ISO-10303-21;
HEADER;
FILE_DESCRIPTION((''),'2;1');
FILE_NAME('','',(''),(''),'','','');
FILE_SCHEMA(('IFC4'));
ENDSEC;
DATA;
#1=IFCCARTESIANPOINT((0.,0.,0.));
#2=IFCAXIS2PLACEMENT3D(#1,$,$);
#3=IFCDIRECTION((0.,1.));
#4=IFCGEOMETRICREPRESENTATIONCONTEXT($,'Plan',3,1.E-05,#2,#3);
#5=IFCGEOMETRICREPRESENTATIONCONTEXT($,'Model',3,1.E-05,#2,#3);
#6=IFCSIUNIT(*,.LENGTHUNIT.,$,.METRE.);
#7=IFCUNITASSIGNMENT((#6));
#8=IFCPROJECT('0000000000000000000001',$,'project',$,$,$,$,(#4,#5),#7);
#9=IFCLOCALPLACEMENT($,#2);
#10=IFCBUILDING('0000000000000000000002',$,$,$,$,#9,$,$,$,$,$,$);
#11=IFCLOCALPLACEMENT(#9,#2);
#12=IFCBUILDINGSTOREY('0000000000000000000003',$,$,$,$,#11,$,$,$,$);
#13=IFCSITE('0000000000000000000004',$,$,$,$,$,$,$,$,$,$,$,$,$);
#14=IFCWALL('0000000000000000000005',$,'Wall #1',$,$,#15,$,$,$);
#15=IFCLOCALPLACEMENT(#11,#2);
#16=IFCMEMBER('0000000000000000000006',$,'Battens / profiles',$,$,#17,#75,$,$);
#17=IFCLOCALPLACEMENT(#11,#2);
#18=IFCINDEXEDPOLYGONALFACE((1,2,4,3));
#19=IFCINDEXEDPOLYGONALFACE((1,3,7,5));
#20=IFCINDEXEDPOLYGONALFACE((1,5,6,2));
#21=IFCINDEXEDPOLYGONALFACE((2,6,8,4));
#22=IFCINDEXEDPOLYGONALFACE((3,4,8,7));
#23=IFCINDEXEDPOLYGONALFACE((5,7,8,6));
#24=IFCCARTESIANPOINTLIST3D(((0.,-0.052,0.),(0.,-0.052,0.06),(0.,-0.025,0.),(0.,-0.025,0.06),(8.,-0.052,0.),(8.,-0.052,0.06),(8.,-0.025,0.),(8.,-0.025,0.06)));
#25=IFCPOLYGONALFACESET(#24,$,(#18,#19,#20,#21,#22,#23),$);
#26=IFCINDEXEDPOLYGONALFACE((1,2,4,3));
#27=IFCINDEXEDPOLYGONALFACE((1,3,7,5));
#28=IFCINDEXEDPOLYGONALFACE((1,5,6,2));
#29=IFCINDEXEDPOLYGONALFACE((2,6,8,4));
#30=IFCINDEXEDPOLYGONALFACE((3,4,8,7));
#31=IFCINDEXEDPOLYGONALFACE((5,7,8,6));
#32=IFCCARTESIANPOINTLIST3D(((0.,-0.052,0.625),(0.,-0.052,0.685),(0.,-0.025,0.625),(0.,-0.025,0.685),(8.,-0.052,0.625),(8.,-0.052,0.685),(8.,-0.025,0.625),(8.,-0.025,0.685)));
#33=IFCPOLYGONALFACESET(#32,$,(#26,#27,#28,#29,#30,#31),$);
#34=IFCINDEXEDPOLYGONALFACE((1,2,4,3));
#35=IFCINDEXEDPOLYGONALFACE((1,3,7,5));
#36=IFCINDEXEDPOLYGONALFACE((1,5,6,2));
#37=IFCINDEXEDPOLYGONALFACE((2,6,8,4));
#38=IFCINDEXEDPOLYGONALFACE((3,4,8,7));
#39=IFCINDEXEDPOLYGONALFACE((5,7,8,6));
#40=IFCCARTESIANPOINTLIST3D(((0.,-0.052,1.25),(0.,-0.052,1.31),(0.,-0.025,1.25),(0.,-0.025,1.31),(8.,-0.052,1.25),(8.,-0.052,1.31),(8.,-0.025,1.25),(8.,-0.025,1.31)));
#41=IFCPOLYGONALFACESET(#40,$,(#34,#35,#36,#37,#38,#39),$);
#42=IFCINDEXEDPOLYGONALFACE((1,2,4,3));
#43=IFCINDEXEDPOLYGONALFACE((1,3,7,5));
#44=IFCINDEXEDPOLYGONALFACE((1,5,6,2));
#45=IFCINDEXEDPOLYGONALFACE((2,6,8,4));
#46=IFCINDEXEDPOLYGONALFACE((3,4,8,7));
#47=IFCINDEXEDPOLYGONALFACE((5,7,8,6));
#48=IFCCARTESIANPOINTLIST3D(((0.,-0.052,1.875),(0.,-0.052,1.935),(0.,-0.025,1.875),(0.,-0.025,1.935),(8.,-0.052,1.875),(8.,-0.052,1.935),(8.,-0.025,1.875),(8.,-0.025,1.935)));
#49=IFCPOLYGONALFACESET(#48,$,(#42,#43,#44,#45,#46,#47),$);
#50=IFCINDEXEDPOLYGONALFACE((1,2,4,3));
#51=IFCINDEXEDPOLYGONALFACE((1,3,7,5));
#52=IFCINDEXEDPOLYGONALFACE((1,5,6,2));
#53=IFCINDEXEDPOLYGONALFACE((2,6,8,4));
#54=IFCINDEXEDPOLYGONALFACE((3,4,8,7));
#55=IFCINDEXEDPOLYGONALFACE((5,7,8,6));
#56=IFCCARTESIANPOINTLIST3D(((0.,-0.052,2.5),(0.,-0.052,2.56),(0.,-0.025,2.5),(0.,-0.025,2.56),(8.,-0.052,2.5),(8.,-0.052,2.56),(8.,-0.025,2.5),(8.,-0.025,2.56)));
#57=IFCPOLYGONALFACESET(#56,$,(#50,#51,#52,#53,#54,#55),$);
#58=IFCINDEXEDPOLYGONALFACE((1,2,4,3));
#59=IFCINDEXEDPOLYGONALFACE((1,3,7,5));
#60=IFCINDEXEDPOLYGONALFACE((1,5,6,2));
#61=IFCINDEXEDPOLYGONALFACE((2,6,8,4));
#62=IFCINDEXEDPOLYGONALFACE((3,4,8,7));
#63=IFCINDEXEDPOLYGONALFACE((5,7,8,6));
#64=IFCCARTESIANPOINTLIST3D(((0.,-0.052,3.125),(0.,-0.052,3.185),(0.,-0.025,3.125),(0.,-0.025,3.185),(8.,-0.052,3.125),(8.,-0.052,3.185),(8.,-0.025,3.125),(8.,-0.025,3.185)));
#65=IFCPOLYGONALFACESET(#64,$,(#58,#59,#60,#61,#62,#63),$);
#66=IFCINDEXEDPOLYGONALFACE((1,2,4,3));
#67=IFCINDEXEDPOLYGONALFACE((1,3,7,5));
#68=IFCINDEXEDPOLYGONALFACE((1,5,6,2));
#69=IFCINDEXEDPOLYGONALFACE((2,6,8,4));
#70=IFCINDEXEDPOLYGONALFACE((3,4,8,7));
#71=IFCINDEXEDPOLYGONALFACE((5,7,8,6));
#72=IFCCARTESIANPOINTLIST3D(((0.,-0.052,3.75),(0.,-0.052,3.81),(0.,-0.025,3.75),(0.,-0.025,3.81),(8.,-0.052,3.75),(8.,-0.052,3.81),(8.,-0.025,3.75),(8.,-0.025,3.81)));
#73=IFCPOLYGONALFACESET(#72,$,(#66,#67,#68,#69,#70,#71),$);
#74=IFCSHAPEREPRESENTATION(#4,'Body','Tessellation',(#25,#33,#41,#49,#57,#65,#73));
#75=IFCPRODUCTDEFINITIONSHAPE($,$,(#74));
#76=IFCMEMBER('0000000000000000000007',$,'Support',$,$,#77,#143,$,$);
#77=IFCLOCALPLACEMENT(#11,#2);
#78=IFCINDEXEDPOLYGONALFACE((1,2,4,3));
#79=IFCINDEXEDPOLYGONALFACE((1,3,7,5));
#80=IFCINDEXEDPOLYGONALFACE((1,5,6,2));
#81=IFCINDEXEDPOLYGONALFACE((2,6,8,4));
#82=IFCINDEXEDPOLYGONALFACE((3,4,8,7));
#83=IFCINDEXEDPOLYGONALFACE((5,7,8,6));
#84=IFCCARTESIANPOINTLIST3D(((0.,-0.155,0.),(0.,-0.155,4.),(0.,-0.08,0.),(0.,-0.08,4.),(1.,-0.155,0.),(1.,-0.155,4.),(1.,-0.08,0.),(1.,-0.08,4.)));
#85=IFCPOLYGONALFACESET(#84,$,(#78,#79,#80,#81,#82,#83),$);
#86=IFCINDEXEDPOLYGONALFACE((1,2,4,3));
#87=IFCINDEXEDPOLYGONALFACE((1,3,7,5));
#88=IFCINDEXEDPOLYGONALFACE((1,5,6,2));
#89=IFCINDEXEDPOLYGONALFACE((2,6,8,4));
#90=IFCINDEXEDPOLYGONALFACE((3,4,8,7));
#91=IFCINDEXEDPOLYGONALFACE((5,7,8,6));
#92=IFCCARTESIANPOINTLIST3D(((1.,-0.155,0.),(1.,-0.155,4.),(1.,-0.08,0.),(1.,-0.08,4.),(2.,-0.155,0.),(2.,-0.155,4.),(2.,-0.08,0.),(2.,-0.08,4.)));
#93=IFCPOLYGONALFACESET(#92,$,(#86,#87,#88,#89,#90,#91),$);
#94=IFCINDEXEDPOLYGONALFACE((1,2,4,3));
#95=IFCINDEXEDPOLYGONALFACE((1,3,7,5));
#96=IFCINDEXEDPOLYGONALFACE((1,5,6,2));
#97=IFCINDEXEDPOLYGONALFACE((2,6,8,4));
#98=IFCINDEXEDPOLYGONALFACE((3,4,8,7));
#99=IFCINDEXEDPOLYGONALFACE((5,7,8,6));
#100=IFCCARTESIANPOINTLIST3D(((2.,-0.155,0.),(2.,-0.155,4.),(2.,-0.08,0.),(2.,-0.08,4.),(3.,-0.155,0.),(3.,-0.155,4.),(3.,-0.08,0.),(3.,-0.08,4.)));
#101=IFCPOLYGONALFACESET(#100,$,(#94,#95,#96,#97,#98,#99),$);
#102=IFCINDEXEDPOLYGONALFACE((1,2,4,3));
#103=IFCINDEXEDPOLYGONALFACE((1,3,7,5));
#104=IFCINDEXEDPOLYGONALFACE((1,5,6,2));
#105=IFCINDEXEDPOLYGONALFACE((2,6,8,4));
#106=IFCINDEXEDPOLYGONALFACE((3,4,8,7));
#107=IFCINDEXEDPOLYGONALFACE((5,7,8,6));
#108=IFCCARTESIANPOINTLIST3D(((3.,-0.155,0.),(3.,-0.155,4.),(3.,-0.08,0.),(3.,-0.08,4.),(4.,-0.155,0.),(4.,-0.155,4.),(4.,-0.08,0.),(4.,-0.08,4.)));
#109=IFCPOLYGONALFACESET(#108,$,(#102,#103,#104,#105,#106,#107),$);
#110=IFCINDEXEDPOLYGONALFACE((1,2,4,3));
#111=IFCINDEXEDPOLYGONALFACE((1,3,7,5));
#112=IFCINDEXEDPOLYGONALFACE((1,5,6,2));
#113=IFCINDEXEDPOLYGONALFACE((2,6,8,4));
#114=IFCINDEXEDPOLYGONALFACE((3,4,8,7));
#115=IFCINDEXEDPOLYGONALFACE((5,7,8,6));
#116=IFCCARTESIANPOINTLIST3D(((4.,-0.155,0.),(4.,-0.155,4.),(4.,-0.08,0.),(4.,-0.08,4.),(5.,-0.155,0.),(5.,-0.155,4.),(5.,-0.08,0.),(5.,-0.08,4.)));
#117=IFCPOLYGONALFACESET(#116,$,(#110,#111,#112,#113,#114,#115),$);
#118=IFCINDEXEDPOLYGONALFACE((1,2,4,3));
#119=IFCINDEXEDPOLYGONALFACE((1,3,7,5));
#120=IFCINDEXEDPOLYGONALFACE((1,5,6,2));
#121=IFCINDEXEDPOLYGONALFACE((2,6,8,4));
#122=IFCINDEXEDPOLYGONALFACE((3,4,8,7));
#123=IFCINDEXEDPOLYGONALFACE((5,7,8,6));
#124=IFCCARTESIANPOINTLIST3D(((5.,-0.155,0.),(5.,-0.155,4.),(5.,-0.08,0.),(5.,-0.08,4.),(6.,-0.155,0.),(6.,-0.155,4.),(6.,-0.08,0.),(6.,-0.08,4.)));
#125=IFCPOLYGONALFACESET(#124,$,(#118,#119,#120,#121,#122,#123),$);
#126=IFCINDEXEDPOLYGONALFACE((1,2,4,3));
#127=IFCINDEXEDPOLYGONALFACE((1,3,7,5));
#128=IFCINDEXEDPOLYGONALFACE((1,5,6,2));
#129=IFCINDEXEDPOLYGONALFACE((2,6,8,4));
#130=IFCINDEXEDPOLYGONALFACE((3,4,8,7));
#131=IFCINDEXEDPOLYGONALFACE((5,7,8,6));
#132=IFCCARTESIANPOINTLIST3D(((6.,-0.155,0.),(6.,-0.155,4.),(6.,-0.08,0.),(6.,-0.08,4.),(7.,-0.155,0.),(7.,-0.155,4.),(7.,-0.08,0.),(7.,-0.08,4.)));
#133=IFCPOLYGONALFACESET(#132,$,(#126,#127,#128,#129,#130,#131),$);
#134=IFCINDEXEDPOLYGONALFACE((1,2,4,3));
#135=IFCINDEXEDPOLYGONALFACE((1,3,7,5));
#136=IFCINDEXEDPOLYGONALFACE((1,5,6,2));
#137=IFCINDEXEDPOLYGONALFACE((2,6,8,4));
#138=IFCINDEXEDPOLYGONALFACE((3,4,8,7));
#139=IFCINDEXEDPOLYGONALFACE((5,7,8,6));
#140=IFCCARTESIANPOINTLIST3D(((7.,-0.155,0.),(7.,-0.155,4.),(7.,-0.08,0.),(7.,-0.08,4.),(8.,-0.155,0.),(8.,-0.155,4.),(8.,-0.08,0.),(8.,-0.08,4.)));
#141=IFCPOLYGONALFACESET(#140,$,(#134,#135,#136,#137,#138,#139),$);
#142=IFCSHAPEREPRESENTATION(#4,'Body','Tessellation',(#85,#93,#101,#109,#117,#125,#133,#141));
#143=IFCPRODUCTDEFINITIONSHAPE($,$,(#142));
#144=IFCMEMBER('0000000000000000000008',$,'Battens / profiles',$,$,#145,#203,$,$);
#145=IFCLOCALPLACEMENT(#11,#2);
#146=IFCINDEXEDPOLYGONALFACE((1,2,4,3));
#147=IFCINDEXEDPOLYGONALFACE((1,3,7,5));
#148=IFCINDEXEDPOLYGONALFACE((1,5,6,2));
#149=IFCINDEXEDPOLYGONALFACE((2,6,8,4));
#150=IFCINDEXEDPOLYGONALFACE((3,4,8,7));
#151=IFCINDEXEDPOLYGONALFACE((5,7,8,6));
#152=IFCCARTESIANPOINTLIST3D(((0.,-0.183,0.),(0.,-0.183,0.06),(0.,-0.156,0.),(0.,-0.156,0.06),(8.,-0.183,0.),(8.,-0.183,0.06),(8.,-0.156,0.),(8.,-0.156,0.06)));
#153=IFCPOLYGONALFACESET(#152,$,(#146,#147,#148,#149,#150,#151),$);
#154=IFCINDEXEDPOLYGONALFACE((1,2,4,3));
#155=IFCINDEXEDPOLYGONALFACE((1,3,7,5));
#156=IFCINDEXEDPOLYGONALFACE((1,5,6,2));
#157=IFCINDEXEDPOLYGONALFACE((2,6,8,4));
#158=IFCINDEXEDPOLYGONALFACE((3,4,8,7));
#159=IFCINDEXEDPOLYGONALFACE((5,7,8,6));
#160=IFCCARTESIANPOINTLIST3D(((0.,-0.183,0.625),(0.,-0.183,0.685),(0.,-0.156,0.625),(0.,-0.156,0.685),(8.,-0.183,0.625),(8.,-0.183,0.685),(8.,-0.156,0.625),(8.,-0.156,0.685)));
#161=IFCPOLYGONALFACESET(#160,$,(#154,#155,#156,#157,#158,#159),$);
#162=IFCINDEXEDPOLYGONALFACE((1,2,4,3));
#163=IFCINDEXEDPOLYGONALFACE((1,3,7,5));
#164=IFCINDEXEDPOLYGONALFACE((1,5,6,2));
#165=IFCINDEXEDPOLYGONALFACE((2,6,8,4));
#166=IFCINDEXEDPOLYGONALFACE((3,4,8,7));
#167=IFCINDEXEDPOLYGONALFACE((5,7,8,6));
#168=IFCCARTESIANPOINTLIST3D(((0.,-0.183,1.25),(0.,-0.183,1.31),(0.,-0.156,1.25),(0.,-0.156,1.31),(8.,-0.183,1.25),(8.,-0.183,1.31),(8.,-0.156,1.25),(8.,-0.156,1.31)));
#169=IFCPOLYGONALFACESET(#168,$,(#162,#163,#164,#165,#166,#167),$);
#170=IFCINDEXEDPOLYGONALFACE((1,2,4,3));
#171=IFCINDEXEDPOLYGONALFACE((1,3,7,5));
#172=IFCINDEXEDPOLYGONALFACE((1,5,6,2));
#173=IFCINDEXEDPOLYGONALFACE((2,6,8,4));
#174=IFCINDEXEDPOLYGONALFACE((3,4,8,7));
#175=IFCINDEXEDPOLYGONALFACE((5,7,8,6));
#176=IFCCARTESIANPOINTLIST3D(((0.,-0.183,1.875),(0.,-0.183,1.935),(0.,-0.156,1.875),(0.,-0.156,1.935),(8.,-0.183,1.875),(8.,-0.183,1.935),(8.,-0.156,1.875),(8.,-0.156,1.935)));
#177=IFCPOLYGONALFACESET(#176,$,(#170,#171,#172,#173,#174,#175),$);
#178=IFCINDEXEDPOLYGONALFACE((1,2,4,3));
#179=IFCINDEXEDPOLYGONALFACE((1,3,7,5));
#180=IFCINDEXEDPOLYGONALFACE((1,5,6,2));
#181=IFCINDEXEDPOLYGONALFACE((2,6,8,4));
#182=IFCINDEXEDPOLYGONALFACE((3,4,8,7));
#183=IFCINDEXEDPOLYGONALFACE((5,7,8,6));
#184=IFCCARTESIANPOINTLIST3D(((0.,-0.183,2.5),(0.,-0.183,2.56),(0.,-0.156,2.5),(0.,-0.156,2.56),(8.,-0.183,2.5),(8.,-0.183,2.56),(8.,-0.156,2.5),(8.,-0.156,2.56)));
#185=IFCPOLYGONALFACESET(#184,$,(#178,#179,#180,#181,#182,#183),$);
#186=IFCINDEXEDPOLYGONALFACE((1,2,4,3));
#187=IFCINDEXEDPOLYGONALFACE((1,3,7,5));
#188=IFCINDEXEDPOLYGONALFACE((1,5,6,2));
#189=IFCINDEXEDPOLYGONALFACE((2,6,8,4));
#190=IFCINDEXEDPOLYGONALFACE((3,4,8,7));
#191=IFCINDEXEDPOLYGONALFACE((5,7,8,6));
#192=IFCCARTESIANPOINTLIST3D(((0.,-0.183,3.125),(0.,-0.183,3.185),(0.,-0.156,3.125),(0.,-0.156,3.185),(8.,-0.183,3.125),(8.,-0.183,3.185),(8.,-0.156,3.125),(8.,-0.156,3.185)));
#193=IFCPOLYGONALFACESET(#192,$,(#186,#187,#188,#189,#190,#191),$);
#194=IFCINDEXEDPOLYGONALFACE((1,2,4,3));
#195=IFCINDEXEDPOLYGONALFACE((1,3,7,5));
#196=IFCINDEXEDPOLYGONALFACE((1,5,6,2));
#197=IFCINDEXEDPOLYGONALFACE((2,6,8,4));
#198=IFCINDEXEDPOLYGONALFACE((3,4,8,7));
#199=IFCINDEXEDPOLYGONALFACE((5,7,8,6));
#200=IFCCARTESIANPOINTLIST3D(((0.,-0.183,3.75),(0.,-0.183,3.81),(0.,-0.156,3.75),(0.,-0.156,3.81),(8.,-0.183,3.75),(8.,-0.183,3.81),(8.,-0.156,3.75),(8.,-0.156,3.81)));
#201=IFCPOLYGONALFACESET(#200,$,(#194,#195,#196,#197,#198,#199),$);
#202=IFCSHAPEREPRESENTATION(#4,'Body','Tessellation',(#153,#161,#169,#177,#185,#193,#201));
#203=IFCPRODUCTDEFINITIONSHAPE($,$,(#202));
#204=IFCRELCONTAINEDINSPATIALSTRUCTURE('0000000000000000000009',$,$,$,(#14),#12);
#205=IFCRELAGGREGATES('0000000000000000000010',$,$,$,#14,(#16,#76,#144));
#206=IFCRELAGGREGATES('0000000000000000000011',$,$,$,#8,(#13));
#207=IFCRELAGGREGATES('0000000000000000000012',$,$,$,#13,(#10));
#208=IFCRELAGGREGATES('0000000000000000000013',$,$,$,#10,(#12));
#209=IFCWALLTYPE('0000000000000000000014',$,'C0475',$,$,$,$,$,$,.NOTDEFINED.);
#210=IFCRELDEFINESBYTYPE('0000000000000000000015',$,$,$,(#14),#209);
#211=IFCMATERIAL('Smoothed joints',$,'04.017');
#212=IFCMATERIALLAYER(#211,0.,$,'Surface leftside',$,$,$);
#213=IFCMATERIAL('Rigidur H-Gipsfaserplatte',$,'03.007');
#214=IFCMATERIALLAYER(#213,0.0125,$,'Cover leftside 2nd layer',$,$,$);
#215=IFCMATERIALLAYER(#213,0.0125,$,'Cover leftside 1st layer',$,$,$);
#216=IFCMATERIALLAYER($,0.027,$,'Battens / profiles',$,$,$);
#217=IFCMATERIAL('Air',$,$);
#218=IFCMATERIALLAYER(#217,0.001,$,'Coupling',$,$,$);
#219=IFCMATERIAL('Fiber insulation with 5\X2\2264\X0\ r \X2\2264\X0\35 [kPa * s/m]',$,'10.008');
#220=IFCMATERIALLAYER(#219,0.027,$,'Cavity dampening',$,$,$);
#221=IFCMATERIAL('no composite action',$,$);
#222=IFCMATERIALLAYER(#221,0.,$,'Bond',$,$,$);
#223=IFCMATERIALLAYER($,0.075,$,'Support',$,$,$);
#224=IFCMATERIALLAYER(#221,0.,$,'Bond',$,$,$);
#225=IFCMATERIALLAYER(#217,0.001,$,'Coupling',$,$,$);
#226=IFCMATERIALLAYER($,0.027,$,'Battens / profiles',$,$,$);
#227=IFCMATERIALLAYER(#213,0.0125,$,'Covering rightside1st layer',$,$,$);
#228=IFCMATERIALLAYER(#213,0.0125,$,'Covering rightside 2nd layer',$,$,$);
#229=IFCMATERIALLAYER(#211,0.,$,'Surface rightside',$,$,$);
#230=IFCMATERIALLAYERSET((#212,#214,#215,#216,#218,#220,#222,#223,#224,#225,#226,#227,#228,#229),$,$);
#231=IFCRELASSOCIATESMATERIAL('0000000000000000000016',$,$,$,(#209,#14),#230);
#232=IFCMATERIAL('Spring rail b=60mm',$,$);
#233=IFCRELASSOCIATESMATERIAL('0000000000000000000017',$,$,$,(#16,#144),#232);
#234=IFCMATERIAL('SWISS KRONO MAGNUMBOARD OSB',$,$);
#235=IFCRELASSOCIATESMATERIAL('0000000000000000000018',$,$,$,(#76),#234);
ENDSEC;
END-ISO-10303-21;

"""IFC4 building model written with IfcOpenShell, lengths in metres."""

from ifc_helpers import new_model, si_unit, direction, frame, frame_2d, origin, place, context, project, spatial, rectangle, extrude, material, layer, layer_set, type_object, element, aggregate, save


model = new_model("IFC4")

# Units and contexts
plan_context = context("Plan", 3, precision=1e-05, world=origin(), true_north=direction((0.0, 1.0)))
model_context = context("Model", 3, precision=1e-05, world=origin(), true_north=direction((0.0, 1.0)))
ifc_project = project(units=[si_unit("LENGTHUNIT", "METRE")], contexts=[plan_context, model_context])

# Site, building, storey
site = spatial("IfcSite", under=ifc_project)
building_placement = place(None, origin())
building = spatial("IfcBuilding", under=site, at=building_placement)
storey_placement = place(building_placement, origin())
storey = spatial("IfcBuildingStorey", under=building, at=storey_placement)

# Wall, members
ifc_material_1 = material(Name="Smoothed joints", Category="04.017")
ifc_layer_1 = layer(ifc_material_1, 0.0, Name="Surface leftside")
ifc_material_2 = material(Name="Rigidur H-Gipsfaserplatte", Category="03.007")
ifc_layer_2 = layer(ifc_material_2, 0.0125, Name="Cover leftside 2nd layer")
ifc_layer_3 = layer(ifc_material_2, 0.0125, Name="Cover leftside 1st layer")
ifc_layer_4 = layer(None, 0.027, Name="Battens / profiles")
ifc_material_3 = material(Name="Air")
ifc_layer_5 = layer(ifc_material_3, 0.001, Name="Coupling")
ifc_material_4 = material(Name="Fiber insulation with 5≤ r ≤35 [kPa * s/m]", Category="10.008")
ifc_layer_6 = layer(ifc_material_4, 0.027, Name="Cavity dampening")
ifc_material_5 = material(Name="no composite action")
ifc_layer_7 = layer(ifc_material_5, 0.0, Name="Bond")
ifc_layer_8 = layer(None, 0.075, Name="Support")
ifc_layer_9 = layer(ifc_material_5, 0.0, Name="Bond")
ifc_layer_10 = layer(ifc_material_3, 0.001, Name="Coupling")
ifc_layer_11 = layer(None, 0.027, Name="Battens / profiles")
ifc_layer_12 = layer(ifc_material_2, 0.0125, Name="Covering rightside1st layer")
ifc_layer_13 = layer(ifc_material_2, 0.0125, Name="Covering rightside 2nd layer")
ifc_layer_14 = layer(ifc_material_1, 0.0, Name="Surface rightside")
ifc_layer_set = layer_set([ifc_layer_1, ifc_layer_2, ifc_layer_3, ifc_layer_4, ifc_layer_5, ifc_layer_6, ifc_layer_7, ifc_layer_8, ifc_layer_9, ifc_layer_10, ifc_layer_11, ifc_layer_12, ifc_layer_13, ifc_layer_14])
wall_type = type_object("IfcWallType", Name="C0475", PredefinedType="NOTDEFINED", material=ifc_layer_set)
wall_placement = place(None, frame((0.0, 0.0, 0.0), z_axis=(0.0, -1.0, 0.0), x_axis=(1.0, 0.0, 0.0)))
wall = element("IfcWall", 1, at=wall_placement, inside=storey, type_object=wall_type, material=ifc_layer_set, Name="Wall #1")
ifc_material_6 = material(Name="Spring rail b=60mm")
member_1_placement = place(wall_placement, origin())
member_1 = element("IfcMember", 2, at=member_1_placement, material=ifc_material_6, Name="Battens / profiles", context=plan_context, shape_type="SweptSolid", body=[
    extrude(rectangle(XDim=0.06, YDim=0.027, at=frame_2d((0.03, 0.0135), x_axis=(1.0, 0.0))), frame((0.0, 0.0, 0.025), z_axis=(1.0, 0.0, 0.0), x_axis=(0.0, 1.0, 0.0)), (0.0, 0.0, 1.0), 8.0),
    extrude(rectangle(XDim=0.06, YDim=0.027, at=frame_2d((0.03, 0.0135), x_axis=(1.0, 0.0))), frame((0.0, 0.625, 0.025), z_axis=(1.0, 0.0, 0.0), x_axis=(0.0, 1.0, 0.0)), (0.0, 0.0, 1.0), 8.0),
    extrude(rectangle(XDim=0.06, YDim=0.027, at=frame_2d((0.03, 0.0135), x_axis=(1.0, 0.0))), frame((0.0, 1.25, 0.025), z_axis=(1.0, 0.0, 0.0), x_axis=(0.0, 1.0, 0.0)), (0.0, 0.0, 1.0), 8.0),
    extrude(rectangle(XDim=0.06, YDim=0.027, at=frame_2d((0.03, 0.0135), x_axis=(1.0, 0.0))), frame((0.0, 1.875, 0.025), z_axis=(1.0, 0.0, 0.0), x_axis=(0.0, 1.0, 0.0)), (0.0, 0.0, 1.0), 8.0),
    extrude(rectangle(XDim=0.06, YDim=0.027, at=frame_2d((0.03, 0.0135), x_axis=(1.0, 0.0))), frame((0.0, 2.5, 0.025), z_axis=(1.0, 0.0, 0.0), x_axis=(0.0, 1.0, 0.0)), (0.0, 0.0, 1.0), 8.0),
    extrude(rectangle(XDim=0.06, YDim=0.027, at=frame_2d((0.03, 0.0135), x_axis=(1.0, 0.0))), frame((0.0, 3.125, 0.025), z_axis=(1.0, 0.0, 0.0), x_axis=(0.0, 1.0, 0.0)), (0.0, 0.0, 1.0), 8.0),
    extrude(rectangle(XDim=0.06, YDim=0.027, at=frame_2d((0.03, 0.0135), x_axis=(1.0, 0.0))), frame((0.0, 3.75, 0.025), z_axis=(1.0, 0.0, 0.0), x_axis=(0.0, 1.0, 0.0)), (0.0, 0.0, 1.0), 8.0),
])
ifc_material_7 = material(Name="SWISS KRONO MAGNUMBOARD OSB")
member_2_placement = place(wall_placement, origin())
member_2 = element("IfcMember", 3, at=member_2_placement, material=ifc_material_7, Name="Support", context=plan_context, shape_type="SweptSolid", body=[
    extrude(rectangle(XDim=1.0, YDim=0.075, at=frame_2d((0.5, 0.0375), x_axis=(1.0, 0.0))), frame((0.0, 4.0, 0.08), z_axis=(0.0, -1.0, 0.0), x_axis=(1.0, 0.0, 0.0)), (0.0, 0.0, 1.0), 4.0),
    extrude(rectangle(XDim=1.0, YDim=0.075, at=frame_2d((0.5, 0.0375), x_axis=(1.0, 0.0))), frame((1.0, 4.0, 0.08), z_axis=(0.0, -1.0, 0.0), x_axis=(1.0, 0.0, 0.0)), (0.0, 0.0, 1.0), 4.0),
    extrude(rectangle(XDim=1.0, YDim=0.075, at=frame_2d((0.5, 0.0375), x_axis=(1.0, 0.0))), frame((2.0, 4.0, 0.08), z_axis=(0.0, -1.0, 0.0), x_axis=(1.0, 0.0, 0.0)), (0.0, 0.0, 1.0), 4.0),
    extrude(rectangle(XDim=1.0, YDim=0.075, at=frame_2d((0.5, 0.0375), x_axis=(1.0, 0.0))), frame((3.0, 4.0, 0.08), z_axis=(0.0, -1.0, 0.0), x_axis=(1.0, 0.0, 0.0)), (0.0, 0.0, 1.0), 4.0),
    extrude(rectangle(XDim=1.0, YDim=0.075, at=frame_2d((0.5, 0.0375), x_axis=(1.0, 0.0))), frame((4.0, 4.0, 0.08), z_axis=(0.0, -1.0, 0.0), x_axis=(1.0, 0.0, 0.0)), (0.0, 0.0, 1.0), 4.0),
    extrude(rectangle(XDim=1.0, YDim=0.075, at=frame_2d((0.5, 0.0375), x_axis=(1.0, 0.0))), frame((5.0, 4.0, 0.08), z_axis=(0.0, -1.0, 0.0), x_axis=(1.0, 0.0, 0.0)), (0.0, 0.0, 1.0), 4.0),
    extrude(rectangle(XDim=1.0, YDim=0.075, at=frame_2d((0.5, 0.0375), x_axis=(1.0, 0.0))), frame((6.0, 4.0, 0.08), z_axis=(0.0, -1.0, 0.0), x_axis=(1.0, 0.0, 0.0)), (0.0, 0.0, 1.0), 4.0),
    extrude(rectangle(XDim=1.0, YDim=0.075, at=frame_2d((0.5, 0.0375), x_axis=(1.0, 0.0))), frame((7.0, 4.0, 0.08), z_axis=(0.0, -1.0, 0.0), x_axis=(1.0, 0.0, 0.0)), (0.0, 0.0, 1.0), 4.0),
])
member_3_placement = place(wall_placement, origin())
member_3 = element("IfcMember", 4, at=member_3_placement, material=ifc_material_6, Name="Battens / profiles", context=plan_context, shape_type="SweptSolid", body=[
    extrude(rectangle(XDim=0.06, YDim=0.027, at=frame_2d((0.03, 0.0135), x_axis=(1.0, 0.0))), frame((0.0, 0.0, 0.156), z_axis=(1.0, 0.0, 0.0), x_axis=(0.0, 1.0, 0.0)), (0.0, 0.0, 1.0), 8.0),
    extrude(rectangle(XDim=0.06, YDim=0.027, at=frame_2d((0.03, 0.0135), x_axis=(1.0, 0.0))), frame((0.0, 0.625, 0.156), z_axis=(1.0, 0.0, 0.0), x_axis=(0.0, 1.0, 0.0)), (0.0, 0.0, 1.0), 8.0),
    extrude(rectangle(XDim=0.06, YDim=0.027, at=frame_2d((0.03, 0.0135), x_axis=(1.0, 0.0))), frame((0.0, 1.25, 0.156), z_axis=(1.0, 0.0, 0.0), x_axis=(0.0, 1.0, 0.0)), (0.0, 0.0, 1.0), 8.0),
    extrude(rectangle(XDim=0.06, YDim=0.027, at=frame_2d((0.03, 0.0135), x_axis=(1.0, 0.0))), frame((0.0, 1.875, 0.156), z_axis=(1.0, 0.0, 0.0), x_axis=(0.0, 1.0, 0.0)), (0.0, 0.0, 1.0), 8.0),
    extrude(rectangle(XDim=0.06, YDim=0.027, at=frame_2d((0.03, 0.0135), x_axis=(1.0, 0.0))), frame((0.0, 2.5, 0.156), z_axis=(1.0, 0.0, 0.0), x_axis=(0.0, 1.0, 0.0)), (0.0, 0.0, 1.0), 8.0),
    extrude(rectangle(XDim=0.06, YDim=0.027, at=frame_2d((0.03, 0.0135), x_axis=(1.0, 0.0))), frame((0.0, 3.125, 0.156), z_axis=(1.0, 0.0, 0.0), x_axis=(0.0, 1.0, 0.0)), (0.0, 0.0, 1.0), 8.0),
    extrude(rectangle(XDim=0.06, YDim=0.027, at=frame_2d((0.03, 0.0135), x_axis=(1.0, 0.0))), frame((0.0, 3.75, 0.156), z_axis=(1.0, 0.0, 0.0), x_axis=(0.0, 1.0, 0.0)), (0.0, 0.0, 1.0), 8.0),
])
aggregate(wall, [member_1, member_2, member_3])

save(model, "model.ifc")
